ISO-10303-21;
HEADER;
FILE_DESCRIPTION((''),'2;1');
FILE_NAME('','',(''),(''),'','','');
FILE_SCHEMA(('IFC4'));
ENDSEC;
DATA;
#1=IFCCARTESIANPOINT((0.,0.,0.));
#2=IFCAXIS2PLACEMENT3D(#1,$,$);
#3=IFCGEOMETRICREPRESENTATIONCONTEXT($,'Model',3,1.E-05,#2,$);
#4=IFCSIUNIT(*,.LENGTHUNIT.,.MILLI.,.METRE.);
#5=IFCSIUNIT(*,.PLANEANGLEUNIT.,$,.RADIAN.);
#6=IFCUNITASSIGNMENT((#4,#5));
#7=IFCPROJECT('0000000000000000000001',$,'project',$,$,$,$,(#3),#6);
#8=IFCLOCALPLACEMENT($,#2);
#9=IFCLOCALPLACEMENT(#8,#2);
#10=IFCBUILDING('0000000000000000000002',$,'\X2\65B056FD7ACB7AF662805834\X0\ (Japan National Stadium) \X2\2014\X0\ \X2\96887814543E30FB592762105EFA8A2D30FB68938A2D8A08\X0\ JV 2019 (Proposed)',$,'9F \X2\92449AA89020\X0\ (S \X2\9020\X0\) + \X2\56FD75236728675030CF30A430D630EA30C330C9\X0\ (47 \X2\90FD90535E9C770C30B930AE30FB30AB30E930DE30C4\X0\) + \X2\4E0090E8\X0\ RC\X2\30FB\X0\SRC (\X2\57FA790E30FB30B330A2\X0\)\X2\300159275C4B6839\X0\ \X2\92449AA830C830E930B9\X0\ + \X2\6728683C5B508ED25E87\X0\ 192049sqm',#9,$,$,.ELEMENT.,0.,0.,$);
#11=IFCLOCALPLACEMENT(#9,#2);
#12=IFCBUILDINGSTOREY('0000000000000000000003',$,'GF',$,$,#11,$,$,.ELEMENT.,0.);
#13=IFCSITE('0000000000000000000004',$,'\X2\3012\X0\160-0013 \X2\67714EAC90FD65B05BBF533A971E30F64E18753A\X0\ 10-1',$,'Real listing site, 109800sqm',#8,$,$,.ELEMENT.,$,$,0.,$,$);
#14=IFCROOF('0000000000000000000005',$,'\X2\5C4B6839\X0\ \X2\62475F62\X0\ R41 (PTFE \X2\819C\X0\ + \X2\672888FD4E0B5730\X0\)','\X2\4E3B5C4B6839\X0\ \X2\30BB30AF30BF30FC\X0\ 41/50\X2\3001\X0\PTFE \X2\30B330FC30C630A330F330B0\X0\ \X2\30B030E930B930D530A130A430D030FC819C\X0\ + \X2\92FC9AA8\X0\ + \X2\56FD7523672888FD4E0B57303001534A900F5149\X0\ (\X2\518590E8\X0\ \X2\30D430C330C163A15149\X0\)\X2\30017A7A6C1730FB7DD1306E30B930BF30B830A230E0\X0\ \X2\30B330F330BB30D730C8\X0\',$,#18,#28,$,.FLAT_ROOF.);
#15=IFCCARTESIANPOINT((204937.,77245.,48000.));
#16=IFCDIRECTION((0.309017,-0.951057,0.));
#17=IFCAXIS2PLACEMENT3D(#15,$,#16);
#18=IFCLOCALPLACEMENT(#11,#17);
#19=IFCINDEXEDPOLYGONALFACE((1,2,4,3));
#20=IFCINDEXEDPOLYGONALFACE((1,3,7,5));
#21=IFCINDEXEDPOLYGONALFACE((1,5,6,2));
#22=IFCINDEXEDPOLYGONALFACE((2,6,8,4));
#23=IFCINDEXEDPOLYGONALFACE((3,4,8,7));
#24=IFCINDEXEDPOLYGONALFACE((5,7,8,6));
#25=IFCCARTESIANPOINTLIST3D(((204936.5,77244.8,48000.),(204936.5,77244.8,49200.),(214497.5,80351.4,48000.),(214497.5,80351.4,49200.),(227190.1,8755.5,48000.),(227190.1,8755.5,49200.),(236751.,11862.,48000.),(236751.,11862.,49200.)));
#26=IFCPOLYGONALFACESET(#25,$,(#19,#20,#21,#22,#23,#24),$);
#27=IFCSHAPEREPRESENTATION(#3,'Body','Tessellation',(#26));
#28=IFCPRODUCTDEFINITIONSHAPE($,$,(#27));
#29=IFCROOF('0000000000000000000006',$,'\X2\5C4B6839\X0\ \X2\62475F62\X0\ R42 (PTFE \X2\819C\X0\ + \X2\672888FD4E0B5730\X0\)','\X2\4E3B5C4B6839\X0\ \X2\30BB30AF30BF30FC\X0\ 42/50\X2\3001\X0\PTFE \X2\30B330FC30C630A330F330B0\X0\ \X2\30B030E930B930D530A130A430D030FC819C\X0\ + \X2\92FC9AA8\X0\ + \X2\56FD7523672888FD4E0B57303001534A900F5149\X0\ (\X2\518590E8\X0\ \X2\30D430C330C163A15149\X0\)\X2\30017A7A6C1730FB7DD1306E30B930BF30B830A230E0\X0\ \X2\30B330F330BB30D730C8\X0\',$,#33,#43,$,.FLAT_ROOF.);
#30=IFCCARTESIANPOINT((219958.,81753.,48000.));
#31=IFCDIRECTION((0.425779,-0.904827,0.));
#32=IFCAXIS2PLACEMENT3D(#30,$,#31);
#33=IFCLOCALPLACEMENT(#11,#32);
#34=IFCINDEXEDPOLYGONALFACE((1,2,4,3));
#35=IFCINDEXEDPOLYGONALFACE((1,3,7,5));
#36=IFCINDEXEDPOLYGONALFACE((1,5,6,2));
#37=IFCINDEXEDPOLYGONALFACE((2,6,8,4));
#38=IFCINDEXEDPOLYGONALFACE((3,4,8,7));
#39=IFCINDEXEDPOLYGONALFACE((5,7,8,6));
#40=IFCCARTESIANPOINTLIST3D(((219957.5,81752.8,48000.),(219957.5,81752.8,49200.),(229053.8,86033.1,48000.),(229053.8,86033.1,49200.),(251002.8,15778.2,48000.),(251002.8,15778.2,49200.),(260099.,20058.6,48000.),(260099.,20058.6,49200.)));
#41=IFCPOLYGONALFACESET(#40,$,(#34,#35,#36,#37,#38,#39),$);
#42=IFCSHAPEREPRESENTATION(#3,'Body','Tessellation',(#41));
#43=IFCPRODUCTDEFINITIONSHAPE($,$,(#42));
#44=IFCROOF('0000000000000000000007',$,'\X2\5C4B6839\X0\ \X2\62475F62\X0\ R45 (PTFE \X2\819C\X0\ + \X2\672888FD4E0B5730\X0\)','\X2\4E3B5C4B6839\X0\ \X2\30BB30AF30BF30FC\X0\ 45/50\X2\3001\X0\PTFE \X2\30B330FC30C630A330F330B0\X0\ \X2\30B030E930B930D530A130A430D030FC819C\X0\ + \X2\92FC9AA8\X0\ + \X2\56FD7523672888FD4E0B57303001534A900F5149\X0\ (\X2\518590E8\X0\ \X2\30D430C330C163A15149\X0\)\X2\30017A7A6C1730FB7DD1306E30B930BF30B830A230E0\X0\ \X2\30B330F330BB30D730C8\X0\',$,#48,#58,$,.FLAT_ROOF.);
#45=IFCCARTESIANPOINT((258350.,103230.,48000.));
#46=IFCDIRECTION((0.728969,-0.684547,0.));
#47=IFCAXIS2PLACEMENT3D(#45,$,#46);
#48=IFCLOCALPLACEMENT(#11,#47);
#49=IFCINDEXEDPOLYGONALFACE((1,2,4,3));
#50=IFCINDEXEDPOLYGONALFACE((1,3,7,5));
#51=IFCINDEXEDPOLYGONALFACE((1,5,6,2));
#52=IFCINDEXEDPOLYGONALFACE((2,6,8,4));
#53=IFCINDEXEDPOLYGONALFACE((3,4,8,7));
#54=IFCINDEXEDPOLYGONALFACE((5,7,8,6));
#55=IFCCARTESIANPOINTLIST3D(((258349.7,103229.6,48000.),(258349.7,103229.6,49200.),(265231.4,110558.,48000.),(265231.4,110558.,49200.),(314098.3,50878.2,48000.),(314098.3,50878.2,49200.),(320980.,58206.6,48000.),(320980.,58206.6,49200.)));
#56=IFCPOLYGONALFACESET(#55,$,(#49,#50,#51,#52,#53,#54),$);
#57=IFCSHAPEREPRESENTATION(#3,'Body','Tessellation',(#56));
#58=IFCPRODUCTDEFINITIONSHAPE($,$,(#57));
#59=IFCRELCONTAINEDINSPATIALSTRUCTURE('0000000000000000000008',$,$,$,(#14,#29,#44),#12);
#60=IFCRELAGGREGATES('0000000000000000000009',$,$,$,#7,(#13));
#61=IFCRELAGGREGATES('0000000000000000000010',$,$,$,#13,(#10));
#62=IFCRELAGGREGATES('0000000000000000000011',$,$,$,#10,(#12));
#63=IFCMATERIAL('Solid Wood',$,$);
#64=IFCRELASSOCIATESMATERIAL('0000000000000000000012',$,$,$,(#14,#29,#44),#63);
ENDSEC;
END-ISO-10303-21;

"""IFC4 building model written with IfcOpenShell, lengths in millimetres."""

from ifc_helpers import new_model, si_unit, frame, frame_2d, origin, place, context, project, spatial, rectangle, extrude, material, element, save


model = new_model("IFC4")

# Units and contexts
model_context = context("Model", 3, precision=1e-05, world=origin())
ifc_project = project(units=[si_unit("LENGTHUNIT", "METRE", prefix="MILLI"), si_unit("PLANEANGLEUNIT", "RADIAN")], contexts=[model_context])

# Site, building, storey
site_placement = place(None, origin())
site = spatial("IfcSite", under=ifc_project, at=site_placement, Name="〒160-0013 東京都新宿区霞ヶ丘町 10-1", ObjectType="Real listing site, 109800sqm", CompositionType="ELEMENT", RefElevation=0.0)
building_placement = place(site_placement, origin())
building = spatial("IfcBuilding", under=site, at=building_placement, Name="新国立競技場 (Japan National Stadium) — 隈研吾・大成建設・梓設計 JV 2019 (Proposed)", ObjectType="9F 鉄骨造 (S 造) + 国産木材ハイブリッド (47 都道府県スギ・カラマツ) + 一部 RC・SRC (基礎・コア)、大屋根 鉄骨トラス + 木格子軒庇 192049sqm", CompositionType="ELEMENT", ElevationOfRefHeight=0.0, ElevationOfTerrain=0.0)
storey_placement = place(building_placement, origin())
storey = spatial("IfcBuildingStorey", under=building, at=storey_placement, Name="GF", CompositionType="ELEMENT", Elevation=0.0)

# Shared definitions
ifc_material_1 = material(Name="Solid Wood")

# Roofs
roof_1_placement = place(storey_placement, frame((204937.0, 77245.0, 48000.0), x_axis=(0.309017, -0.951057, 0.0)))
element("IfcRoof", 1, at=roof_1_placement, inside=storey, material=ifc_material_1, Name="屋根 扇形 R41 (PTFE 膜 + 木製下地)", Description="主屋根 セクター 41/50、PTFE コーティング グラスファイバー膜 + 鋼骨 + 国産木製下地、半透光 (内部 ピッチ採光)、空気・緑のスタジアム コンセプト", PredefinedType="FLAT_ROOF", context=model_context, shape_type="SweptSolid", body=[
    extrude(rectangle(XDim=72014.0, YDim=10053.0, at=frame_2d((36007.0, 5026.0))), frame((204937.0, 77245.0, 48000.0), x_axis=(0.309017, -0.951057, 0.0)), (0.0, 0.0, 1.0), 1200.0),
])
roof_2_placement = place(storey_placement, frame((219958.0, 81753.0, 48000.0), x_axis=(0.425779, -0.904827, 0.0)))
element("IfcRoof", 2, at=roof_2_placement, inside=storey, material=ifc_material_1, Name="屋根 扇形 R42 (PTFE 膜 + 木製下地)", Description="主屋根 セクター 42/50、PTFE コーティング グラスファイバー膜 + 鋼骨 + 国産木製下地、半透光 (内部 ピッチ採光)、空気・緑のスタジアム コンセプト", PredefinedType="FLAT_ROOF", context=model_context, shape_type="SweptSolid", body=[
    extrude(rectangle(XDim=72914.0, YDim=10053.0, at=frame_2d((36457.0, 5026.0))), frame((219958.0, 81753.0, 48000.0), x_axis=(0.425779, -0.904827, 0.0)), (0.0, 0.0, 1.0), 1200.0),
])
roof_3_placement = place(storey_placement, frame((258350.0, 103230.0, 48000.0), x_axis=(0.728969, -0.684547, 0.0)))
element("IfcRoof", 3, at=roof_3_placement, inside=storey, material=ifc_material_1, Name="屋根 扇形 R45 (PTFE 膜 + 木製下地)", Description="主屋根 セクター 45/50、PTFE コーティング グラスファイバー膜 + 鋼骨 + 国産木製下地、半透光 (内部 ピッチ採光)、空気・緑のスタジアム コンセプト", PredefinedType="FLAT_ROOF", context=model_context, shape_type="SweptSolid", body=[
    extrude(rectangle(XDim=76476.0, YDim=10053.0, at=frame_2d((38238.0, 5026.0))), frame((258350.0, 103230.0, 48000.0), x_axis=(0.728969, -0.684547, 0.0)), (0.0, 0.0, 1.0), 1200.0),
])

save(model, "model.ifc")
